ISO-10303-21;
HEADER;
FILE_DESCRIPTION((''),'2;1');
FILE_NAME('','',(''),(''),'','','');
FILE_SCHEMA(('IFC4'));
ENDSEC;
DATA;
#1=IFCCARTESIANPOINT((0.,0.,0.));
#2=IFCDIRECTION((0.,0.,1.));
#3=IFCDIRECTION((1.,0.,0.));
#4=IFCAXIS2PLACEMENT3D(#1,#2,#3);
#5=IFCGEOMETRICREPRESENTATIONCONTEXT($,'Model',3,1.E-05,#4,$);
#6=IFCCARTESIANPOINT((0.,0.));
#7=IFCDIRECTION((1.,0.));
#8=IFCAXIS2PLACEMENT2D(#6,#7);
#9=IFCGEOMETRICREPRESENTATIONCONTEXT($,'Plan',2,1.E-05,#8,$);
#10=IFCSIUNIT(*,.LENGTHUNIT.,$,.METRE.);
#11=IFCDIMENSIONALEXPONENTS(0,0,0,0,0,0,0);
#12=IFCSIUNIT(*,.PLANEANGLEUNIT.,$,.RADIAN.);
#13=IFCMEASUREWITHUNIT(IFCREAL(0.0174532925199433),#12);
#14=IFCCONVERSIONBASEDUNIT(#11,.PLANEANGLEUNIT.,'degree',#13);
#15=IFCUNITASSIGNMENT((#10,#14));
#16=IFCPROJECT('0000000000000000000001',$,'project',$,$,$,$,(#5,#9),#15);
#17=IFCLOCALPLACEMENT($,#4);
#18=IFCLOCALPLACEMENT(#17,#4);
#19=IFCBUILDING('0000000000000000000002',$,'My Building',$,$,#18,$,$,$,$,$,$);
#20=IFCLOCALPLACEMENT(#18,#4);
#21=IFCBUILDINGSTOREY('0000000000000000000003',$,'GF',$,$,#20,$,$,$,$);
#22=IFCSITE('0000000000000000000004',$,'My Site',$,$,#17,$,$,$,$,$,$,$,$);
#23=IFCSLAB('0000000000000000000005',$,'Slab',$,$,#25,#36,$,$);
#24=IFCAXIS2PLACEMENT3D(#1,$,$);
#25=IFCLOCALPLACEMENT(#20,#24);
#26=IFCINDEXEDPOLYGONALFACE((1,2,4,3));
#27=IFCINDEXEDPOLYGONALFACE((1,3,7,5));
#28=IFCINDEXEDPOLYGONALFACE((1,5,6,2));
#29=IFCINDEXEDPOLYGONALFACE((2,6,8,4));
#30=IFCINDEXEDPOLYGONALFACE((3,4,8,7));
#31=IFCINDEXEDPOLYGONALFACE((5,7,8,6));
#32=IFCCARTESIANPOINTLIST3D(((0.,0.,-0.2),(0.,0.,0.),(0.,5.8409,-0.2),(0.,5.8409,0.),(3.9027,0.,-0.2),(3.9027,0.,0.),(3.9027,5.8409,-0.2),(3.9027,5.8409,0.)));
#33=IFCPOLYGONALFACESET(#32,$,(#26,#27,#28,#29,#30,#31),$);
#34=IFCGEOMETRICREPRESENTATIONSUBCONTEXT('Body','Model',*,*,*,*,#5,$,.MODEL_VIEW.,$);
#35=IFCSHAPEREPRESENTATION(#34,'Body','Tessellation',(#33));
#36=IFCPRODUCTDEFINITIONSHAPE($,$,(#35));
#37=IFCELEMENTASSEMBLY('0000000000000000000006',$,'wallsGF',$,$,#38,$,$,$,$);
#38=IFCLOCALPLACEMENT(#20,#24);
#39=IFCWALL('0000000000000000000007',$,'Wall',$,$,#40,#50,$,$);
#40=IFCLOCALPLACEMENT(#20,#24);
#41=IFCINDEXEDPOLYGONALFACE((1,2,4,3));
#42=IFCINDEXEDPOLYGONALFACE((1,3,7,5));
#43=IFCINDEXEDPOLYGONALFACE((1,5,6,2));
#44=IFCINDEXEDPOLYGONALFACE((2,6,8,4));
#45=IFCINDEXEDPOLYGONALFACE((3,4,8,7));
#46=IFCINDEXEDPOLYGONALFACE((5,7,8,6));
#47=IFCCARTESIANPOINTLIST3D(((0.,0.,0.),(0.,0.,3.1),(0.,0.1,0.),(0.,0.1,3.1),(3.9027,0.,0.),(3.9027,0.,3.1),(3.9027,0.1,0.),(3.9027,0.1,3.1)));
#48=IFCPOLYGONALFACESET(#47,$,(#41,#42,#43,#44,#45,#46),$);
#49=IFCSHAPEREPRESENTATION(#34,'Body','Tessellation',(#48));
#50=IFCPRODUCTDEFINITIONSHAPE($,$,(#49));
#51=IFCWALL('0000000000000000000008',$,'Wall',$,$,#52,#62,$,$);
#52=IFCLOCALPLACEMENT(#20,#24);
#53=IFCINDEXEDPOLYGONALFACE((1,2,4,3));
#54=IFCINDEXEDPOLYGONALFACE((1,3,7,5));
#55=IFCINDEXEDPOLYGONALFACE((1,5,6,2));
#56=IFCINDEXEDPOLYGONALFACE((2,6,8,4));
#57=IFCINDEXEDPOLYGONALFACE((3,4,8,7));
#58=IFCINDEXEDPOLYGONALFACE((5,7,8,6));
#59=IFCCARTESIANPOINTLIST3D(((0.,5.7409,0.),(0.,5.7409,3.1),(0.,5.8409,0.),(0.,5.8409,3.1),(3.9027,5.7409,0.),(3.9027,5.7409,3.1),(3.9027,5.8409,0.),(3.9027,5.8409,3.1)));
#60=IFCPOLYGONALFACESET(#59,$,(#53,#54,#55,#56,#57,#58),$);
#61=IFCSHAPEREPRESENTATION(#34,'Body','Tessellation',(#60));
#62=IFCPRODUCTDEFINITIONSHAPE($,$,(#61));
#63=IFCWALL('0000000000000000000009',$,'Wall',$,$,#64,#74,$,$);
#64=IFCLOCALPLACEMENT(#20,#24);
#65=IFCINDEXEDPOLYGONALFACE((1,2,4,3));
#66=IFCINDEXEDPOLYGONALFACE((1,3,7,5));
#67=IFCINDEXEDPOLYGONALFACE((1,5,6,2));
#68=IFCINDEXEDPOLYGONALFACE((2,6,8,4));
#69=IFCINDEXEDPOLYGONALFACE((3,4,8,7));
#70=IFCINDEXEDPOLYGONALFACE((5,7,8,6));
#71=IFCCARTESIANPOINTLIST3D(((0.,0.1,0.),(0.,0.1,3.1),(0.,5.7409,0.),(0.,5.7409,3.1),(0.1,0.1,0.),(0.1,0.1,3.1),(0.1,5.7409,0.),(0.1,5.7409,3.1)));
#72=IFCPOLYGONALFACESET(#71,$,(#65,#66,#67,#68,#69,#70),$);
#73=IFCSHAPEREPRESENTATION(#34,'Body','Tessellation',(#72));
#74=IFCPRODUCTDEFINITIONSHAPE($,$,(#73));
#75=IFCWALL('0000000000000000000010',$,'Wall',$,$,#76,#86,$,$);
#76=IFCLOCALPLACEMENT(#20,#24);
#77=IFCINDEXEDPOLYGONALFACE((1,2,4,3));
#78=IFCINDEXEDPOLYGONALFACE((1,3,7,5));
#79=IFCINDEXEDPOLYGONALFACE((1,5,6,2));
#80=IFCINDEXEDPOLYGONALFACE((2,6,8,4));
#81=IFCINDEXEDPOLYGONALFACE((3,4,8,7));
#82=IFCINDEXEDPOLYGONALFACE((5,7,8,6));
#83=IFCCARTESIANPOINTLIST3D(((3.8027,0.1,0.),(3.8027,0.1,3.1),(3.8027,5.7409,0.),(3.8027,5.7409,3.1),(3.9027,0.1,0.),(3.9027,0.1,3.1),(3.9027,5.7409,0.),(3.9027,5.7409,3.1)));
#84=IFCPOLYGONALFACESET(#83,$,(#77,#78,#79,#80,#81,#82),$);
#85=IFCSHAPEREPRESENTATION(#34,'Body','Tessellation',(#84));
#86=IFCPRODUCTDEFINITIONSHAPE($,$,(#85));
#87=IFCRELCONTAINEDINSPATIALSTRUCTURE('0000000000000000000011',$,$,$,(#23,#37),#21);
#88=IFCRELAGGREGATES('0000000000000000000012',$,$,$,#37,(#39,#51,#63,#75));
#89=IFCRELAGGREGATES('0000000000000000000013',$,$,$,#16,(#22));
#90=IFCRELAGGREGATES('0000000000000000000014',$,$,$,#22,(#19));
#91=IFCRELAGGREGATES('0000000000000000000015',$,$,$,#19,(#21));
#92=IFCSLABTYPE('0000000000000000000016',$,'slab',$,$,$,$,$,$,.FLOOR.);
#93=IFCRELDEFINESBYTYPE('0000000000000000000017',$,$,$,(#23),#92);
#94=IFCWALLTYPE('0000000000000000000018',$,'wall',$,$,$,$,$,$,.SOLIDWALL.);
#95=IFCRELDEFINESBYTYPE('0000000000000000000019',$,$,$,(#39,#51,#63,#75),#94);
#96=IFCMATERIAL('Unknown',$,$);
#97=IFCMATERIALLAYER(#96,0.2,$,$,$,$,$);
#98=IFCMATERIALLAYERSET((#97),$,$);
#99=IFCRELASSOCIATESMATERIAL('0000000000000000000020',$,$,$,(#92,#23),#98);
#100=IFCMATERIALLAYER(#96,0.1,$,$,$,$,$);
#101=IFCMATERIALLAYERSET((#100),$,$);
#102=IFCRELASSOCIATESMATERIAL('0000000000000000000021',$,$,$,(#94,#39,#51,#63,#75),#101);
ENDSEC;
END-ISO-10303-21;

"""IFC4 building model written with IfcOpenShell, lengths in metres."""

from ifc_helpers import new_model, entity, si_unit, converted_unit, frame, origin_with_axes, origin_2d_with_axis, place, context, subcontext, project, spatial, line, indexed_curve, outline, extrude, clip, halfspace, material, layer, layer_set, layer_usage, type_object, element, aggregate, save


model = new_model("IFC4")

# Units and contexts
model_context = context("Model", 3, precision=1e-05, world=origin_with_axes())
plan_context = context("Plan", 2, precision=1e-05, world=origin_2d_with_axis())
body_context = subcontext(model_context, "Body", "Model", "MODEL_VIEW")
ifc_project = project(units=[si_unit("LENGTHUNIT", "METRE"), converted_unit("PLANEANGLEUNIT", "degree", entity("IfcReal", 0.0174532925199433), si_unit("PLANEANGLEUNIT", "RADIAN"), dimensions=[0, 0, 0, 0, 0, 0, 0])], contexts=[model_context, plan_context])

# Site, building, storey
site_placement = place(None, origin_with_axes())
site = spatial("IfcSite", under=ifc_project, at=site_placement, Name="My Site")
building_placement = place(site_placement, origin_with_axes())
building = spatial("IfcBuilding", under=site, at=building_placement, Name="My Building")
storey_placement = place(building_placement, origin_with_axes())
storey = spatial("IfcBuildingStorey", under=building, at=storey_placement, Name="GF")

# Slab
ifc_material = material(Name="Unknown")
ifc_layer_1 = layer(ifc_material, 0.2)
ifc_layer_set_1 = layer_set([ifc_layer_1])
ifc_layer_usage_1 = layer_usage(ifc_layer_set_1, "AXIS3", "POSITIVE", 0.0)
slab_type = type_object("IfcSlabType", Name="slab", PredefinedType="FLOOR", material=ifc_layer_set_1)
slab_placement = place(storey_placement, frame((0.0, 0.0, -0.2), z_axis=(0.0, 0.0, 1.0), x_axis=(1.0, 0.0, 0.0)))
element("IfcSlab", 1, at=slab_placement, inside=storey, type_object=slab_type, material=ifc_layer_usage_1, Name="Slab", context=body_context, shape_type="SweptSolid", body=[
    extrude(outline(indexed_curve([(0.0, 0.0), (3.9027, 0.0), (3.9027, 5.8409), (0.0, 5.8409)], segments=[line(3, 2), line(2, 1), line(1, 4), line(4, 3)], self_intersect=False)), None, (0.0, 0.0, 1.0), 0.2),
])

# Element assembly, walls
assembly_placement = place(storey_placement, origin_with_axes())
assembly = element("IfcElementAssembly", 2, at=assembly_placement, inside=storey, Name="wallsGF")
ifc_layer_2 = layer(ifc_material, 0.1)
ifc_layer_set_2 = layer_set([ifc_layer_2])
ifc_layer_usage_2 = layer_usage(ifc_layer_set_2, "AXIS2", "POSITIVE", 0.0)
wall_type = type_object("IfcWallType", Name="wall", PredefinedType="SOLIDWALL", material=ifc_layer_set_2)
wall_1_placement = place(assembly_placement, origin_with_axes())
wall_1 = element("IfcWall", 3, at=wall_1_placement, type_object=wall_type, material=ifc_layer_usage_2, Name="Wall", context=body_context, shape_type="Clipping", body=[
    clip(extrude(outline(indexed_curve([(0.0, 0.0), (0.0, 0.1), (3.9027, 0.1), (3.9027, 0.0), (0.0, 0.0)], self_intersect=False)), origin_with_axes(), (0.0, 0.0, 1.0), 3.1), halfspace(frame((0.0, 0.0, 3.1), z_axis=(0.0, 0.0, 1.0), x_axis=(-1.0, 0.0, 0.0)), False)),
])
ifc_layer_usage_3 = layer_usage(ifc_layer_set_2, "AXIS2", "POSITIVE", 0.0)
wall_2_placement = place(assembly_placement, frame((0.0, 5.7409, 0.0), z_axis=(0.0, 0.0, 1.0), x_axis=(1.0, 0.0, 0.0)))
wall_2 = element("IfcWall", 4, at=wall_2_placement, type_object=wall_type, material=ifc_layer_usage_3, Name="Wall", context=body_context, shape_type="Clipping", body=[
    clip(extrude(outline(indexed_curve([(0.0, 0.0), (0.0, 0.1), (3.9027, 0.1), (3.9027, 0.0), (0.0, 0.0)], self_intersect=False)), origin_with_axes(), (0.0, 0.0, 1.0), 3.1), halfspace(frame((0.0, 0.0, 3.1), z_axis=(0.0, 0.0, 1.0), x_axis=(-1.0, 0.0, 0.0)), False)),
])
ifc_layer_usage_4 = layer_usage(ifc_layer_set_2, "AXIS2", "POSITIVE", 0.0)
wall_3_placement = place(assembly_placement, frame((0.0, 5.7409, 0.0), z_axis=(0.0, 0.0, 1.0), x_axis=(0.0, -1.0, 0.0)))
wall_3 = element("IfcWall", 5, at=wall_3_placement, type_object=wall_type, material=ifc_layer_usage_4, Name="Wall", context=body_context, shape_type="Clipping", body=[
    clip(extrude(outline(indexed_curve([(0.0, 0.0), (0.0, 0.1), (5.6409, 0.1), (5.6409, 0.0), (0.0, 0.0)], self_intersect=False)), origin_with_axes(), (0.0, 0.0, 1.0), 3.1), halfspace(frame((0.0, 0.0, 3.1), z_axis=(0.0, 0.0, 1.0), x_axis=(-1.0, 0.0, 0.0)), False)),
])
ifc_layer_usage_5 = layer_usage(ifc_layer_set_2, "AXIS2", "POSITIVE", 0.0)
wall_4_placement = place(assembly_placement, frame((3.8027, 5.7409, 0.0), z_axis=(0.0, 0.0, 1.0), x_axis=(0.0, -1.0, 0.0)))
wall_4 = element("IfcWall", 6, at=wall_4_placement, type_object=wall_type, material=ifc_layer_usage_5, Name="Wall", context=body_context, shape_type="Clipping", body=[
    clip(extrude(outline(indexed_curve([(0.0, 0.0), (0.0, 0.1), (5.6409, 0.1), (5.6409, 0.0), (0.0, 0.0)], self_intersect=False)), origin_with_axes(), (0.0, 0.0, 1.0), 3.1), halfspace(frame((0.0, 0.0, 3.1), z_axis=(0.0, 0.0, 1.0), x_axis=(-1.0, 0.0, 0.0)), False)),
])
aggregate(assembly, [wall_1, wall_2, wall_3, wall_4])

save(model, "model.ifc")
